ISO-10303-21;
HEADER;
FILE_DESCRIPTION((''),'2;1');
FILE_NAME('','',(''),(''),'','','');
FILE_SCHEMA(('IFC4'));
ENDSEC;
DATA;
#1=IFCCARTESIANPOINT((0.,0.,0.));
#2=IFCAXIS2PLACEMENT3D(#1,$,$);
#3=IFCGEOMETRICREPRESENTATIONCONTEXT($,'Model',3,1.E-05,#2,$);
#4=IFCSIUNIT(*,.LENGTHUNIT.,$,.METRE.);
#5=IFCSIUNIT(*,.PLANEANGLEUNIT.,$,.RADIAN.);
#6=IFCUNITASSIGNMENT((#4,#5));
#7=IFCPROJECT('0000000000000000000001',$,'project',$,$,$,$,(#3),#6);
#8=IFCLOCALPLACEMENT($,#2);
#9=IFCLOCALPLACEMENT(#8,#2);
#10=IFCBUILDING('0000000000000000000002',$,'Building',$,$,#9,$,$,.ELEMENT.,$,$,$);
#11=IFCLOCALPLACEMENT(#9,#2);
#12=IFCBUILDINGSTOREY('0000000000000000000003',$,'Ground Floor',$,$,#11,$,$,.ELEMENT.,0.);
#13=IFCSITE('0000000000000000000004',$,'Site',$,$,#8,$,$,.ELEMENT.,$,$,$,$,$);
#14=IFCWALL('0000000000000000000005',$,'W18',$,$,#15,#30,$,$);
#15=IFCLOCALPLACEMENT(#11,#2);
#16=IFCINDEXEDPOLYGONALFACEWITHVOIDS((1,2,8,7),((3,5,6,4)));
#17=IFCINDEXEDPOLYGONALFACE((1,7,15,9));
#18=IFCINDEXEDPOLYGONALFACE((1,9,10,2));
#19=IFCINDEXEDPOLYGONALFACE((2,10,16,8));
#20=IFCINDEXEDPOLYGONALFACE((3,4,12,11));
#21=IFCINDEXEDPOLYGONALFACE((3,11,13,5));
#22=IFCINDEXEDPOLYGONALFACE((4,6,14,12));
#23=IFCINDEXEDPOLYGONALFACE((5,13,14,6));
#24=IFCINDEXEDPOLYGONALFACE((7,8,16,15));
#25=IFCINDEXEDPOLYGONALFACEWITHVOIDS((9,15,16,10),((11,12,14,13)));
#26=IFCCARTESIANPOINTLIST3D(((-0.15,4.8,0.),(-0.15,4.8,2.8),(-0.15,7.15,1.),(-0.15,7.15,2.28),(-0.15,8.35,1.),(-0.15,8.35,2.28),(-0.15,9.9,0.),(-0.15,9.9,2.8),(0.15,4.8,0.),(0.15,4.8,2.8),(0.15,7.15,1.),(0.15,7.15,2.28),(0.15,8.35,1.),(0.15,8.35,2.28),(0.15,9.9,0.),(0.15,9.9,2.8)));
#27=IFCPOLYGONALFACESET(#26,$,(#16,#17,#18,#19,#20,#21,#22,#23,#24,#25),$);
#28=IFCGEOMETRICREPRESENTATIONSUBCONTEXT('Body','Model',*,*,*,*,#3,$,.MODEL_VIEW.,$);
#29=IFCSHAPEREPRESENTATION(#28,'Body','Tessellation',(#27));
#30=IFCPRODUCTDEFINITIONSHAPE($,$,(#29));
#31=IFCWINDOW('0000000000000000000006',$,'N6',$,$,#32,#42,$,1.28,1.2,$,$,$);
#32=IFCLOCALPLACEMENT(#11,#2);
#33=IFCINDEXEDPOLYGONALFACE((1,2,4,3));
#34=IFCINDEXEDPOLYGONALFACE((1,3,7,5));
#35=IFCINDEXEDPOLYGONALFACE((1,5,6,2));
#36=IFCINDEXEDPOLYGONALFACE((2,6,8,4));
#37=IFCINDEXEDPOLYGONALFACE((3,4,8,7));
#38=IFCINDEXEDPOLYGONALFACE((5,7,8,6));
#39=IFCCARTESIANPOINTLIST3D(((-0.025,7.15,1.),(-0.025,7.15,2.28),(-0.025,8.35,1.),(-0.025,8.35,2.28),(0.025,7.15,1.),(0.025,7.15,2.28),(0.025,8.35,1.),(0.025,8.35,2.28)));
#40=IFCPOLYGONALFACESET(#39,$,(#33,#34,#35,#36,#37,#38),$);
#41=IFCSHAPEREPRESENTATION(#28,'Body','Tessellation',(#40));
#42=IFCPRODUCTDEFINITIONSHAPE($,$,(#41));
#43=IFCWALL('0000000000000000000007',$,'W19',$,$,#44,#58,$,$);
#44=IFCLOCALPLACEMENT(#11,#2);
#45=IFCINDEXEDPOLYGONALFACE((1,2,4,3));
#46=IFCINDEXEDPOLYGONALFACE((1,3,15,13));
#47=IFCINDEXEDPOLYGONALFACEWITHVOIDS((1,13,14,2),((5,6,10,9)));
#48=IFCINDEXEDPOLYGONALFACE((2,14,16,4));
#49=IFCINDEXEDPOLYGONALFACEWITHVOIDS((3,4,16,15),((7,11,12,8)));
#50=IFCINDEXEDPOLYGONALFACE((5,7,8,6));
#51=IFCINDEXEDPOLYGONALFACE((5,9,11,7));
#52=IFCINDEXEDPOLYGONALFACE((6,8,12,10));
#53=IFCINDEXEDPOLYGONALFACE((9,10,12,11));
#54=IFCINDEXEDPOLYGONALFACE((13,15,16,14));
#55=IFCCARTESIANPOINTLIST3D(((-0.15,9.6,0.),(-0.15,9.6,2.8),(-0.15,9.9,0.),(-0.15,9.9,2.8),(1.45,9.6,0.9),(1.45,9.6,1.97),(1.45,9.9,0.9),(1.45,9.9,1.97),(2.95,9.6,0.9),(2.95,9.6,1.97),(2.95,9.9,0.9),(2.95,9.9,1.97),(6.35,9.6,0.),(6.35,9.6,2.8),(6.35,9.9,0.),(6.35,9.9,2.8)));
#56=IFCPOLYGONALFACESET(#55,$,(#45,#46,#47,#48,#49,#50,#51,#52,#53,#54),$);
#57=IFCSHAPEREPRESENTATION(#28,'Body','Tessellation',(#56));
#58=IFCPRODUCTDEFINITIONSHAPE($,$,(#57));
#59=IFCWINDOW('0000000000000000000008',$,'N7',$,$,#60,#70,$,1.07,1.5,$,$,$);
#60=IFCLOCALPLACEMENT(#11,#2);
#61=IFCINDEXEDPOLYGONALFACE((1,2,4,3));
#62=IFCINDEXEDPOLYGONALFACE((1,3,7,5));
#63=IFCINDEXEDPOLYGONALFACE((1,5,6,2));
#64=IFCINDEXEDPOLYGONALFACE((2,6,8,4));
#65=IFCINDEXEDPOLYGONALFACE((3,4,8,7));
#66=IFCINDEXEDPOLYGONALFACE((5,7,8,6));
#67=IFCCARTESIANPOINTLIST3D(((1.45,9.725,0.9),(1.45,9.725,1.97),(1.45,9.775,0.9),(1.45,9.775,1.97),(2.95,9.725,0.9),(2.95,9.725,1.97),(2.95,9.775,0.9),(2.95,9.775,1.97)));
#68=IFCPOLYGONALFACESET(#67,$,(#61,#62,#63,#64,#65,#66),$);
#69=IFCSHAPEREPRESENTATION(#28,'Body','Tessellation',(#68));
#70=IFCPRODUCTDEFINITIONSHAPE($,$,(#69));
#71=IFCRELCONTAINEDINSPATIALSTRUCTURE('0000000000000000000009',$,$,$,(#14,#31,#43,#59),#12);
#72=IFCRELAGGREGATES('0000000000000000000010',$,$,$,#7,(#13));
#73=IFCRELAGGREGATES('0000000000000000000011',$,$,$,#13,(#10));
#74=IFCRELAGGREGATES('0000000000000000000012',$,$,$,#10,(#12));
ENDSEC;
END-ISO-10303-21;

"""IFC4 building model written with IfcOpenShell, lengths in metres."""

from ifc_helpers import new_model, si_unit, frame, frame_2d, origin, origin_2d, place, context, subcontext, project, spatial, rectangle, extrude, element, fill, save


model = new_model("IFC4")

# Units and contexts
model_context = context("Model", 3, precision=1e-05, world=origin())
body_context = subcontext(model_context, "Body", "Model", "MODEL_VIEW")
ifc_project = project(units=[si_unit("LENGTHUNIT", "METRE"), si_unit("PLANEANGLEUNIT", "RADIAN")], contexts=[model_context])

# Site, building, storey
site_placement = place(None, origin())
site = spatial("IfcSite", under=ifc_project, at=site_placement, Name="Site", CompositionType="ELEMENT")
building_placement = place(site_placement, origin())
building = spatial("IfcBuilding", under=site, at=building_placement, Name="Building", CompositionType="ELEMENT")
storey_placement = place(building_placement, origin())
storey = spatial("IfcBuildingStorey", under=building, at=storey_placement, Name="Ground Floor", CompositionType="ELEMENT", Elevation=0.0)

# Walls, openings, windows
wall_1_placement = place(storey_placement, frame((0.0, 4.95, 0.0), x_axis=(0.0, 1.0, 0.0)))
wall_1 = element("IfcWall", 1, at=wall_1_placement, inside=storey, Name="W18", context=body_context, shape_type="SweptSolid", body=[
    extrude(rectangle(XDim=5.1, YDim=0.3, at=frame_2d((2.4, 0.0))), origin(), (0.0, 0.0, 1.0), 2.8),
])
opening_1_placement = place(wall_1_placement, frame((2.8, 0.0, 1.0)))
opening_1 = element("IfcOpeningElement", 2, at=opening_1_placement, cuts=wall_1, context=body_context, shape_type="SweptSolid", body=[
    extrude(rectangle(XDim=1.2, YDim=0.4, at=origin_2d()), origin(), (0.0, 0.0, 1.0), 1.28),
])
window_1_placement = place(opening_1_placement, origin())
window_1 = element("IfcWindow", 3, at=window_1_placement, inside=storey, Name="N6", OverallHeight=1.28, OverallWidth=1.2, context=body_context, shape_type="SweptSolid", body=[
    extrude(rectangle(XDim=1.2, YDim=0.05, at=origin_2d()), origin(), (0.0, 0.0, 1.0), 1.28),
])
fill(opening_1, window_1)
wall_2_placement = place(storey_placement, frame((0.0, 9.75, 0.0), x_axis=(1.0, 0.0, 0.0)))
wall_2 = element("IfcWall", 4, at=wall_2_placement, inside=storey, Name="W19", context=body_context, shape_type="SweptSolid", body=[
    extrude(rectangle(XDim=6.5, YDim=0.3, at=frame_2d((3.1, 0.0))), origin(), (0.0, 0.0, 1.0), 2.8),
])
opening_2_placement = place(wall_2_placement, frame((2.2, 0.0, 0.9)))
opening_2 = element("IfcOpeningElement", 5, at=opening_2_placement, cuts=wall_2, context=body_context, shape_type="SweptSolid", body=[
    extrude(rectangle(XDim=1.5, YDim=0.4, at=origin_2d()), origin(), (0.0, 0.0, 1.0), 1.07),
])
window_2_placement = place(opening_2_placement, origin())
window_2 = element("IfcWindow", 6, at=window_2_placement, inside=storey, Name="N7", OverallHeight=1.07, OverallWidth=1.5, context=body_context, shape_type="SweptSolid", body=[
    extrude(rectangle(XDim=1.5, YDim=0.05, at=origin_2d()), origin(), (0.0, 0.0, 1.0), 1.07),
])
fill(opening_2, window_2)

save(model, "model.ifc")
